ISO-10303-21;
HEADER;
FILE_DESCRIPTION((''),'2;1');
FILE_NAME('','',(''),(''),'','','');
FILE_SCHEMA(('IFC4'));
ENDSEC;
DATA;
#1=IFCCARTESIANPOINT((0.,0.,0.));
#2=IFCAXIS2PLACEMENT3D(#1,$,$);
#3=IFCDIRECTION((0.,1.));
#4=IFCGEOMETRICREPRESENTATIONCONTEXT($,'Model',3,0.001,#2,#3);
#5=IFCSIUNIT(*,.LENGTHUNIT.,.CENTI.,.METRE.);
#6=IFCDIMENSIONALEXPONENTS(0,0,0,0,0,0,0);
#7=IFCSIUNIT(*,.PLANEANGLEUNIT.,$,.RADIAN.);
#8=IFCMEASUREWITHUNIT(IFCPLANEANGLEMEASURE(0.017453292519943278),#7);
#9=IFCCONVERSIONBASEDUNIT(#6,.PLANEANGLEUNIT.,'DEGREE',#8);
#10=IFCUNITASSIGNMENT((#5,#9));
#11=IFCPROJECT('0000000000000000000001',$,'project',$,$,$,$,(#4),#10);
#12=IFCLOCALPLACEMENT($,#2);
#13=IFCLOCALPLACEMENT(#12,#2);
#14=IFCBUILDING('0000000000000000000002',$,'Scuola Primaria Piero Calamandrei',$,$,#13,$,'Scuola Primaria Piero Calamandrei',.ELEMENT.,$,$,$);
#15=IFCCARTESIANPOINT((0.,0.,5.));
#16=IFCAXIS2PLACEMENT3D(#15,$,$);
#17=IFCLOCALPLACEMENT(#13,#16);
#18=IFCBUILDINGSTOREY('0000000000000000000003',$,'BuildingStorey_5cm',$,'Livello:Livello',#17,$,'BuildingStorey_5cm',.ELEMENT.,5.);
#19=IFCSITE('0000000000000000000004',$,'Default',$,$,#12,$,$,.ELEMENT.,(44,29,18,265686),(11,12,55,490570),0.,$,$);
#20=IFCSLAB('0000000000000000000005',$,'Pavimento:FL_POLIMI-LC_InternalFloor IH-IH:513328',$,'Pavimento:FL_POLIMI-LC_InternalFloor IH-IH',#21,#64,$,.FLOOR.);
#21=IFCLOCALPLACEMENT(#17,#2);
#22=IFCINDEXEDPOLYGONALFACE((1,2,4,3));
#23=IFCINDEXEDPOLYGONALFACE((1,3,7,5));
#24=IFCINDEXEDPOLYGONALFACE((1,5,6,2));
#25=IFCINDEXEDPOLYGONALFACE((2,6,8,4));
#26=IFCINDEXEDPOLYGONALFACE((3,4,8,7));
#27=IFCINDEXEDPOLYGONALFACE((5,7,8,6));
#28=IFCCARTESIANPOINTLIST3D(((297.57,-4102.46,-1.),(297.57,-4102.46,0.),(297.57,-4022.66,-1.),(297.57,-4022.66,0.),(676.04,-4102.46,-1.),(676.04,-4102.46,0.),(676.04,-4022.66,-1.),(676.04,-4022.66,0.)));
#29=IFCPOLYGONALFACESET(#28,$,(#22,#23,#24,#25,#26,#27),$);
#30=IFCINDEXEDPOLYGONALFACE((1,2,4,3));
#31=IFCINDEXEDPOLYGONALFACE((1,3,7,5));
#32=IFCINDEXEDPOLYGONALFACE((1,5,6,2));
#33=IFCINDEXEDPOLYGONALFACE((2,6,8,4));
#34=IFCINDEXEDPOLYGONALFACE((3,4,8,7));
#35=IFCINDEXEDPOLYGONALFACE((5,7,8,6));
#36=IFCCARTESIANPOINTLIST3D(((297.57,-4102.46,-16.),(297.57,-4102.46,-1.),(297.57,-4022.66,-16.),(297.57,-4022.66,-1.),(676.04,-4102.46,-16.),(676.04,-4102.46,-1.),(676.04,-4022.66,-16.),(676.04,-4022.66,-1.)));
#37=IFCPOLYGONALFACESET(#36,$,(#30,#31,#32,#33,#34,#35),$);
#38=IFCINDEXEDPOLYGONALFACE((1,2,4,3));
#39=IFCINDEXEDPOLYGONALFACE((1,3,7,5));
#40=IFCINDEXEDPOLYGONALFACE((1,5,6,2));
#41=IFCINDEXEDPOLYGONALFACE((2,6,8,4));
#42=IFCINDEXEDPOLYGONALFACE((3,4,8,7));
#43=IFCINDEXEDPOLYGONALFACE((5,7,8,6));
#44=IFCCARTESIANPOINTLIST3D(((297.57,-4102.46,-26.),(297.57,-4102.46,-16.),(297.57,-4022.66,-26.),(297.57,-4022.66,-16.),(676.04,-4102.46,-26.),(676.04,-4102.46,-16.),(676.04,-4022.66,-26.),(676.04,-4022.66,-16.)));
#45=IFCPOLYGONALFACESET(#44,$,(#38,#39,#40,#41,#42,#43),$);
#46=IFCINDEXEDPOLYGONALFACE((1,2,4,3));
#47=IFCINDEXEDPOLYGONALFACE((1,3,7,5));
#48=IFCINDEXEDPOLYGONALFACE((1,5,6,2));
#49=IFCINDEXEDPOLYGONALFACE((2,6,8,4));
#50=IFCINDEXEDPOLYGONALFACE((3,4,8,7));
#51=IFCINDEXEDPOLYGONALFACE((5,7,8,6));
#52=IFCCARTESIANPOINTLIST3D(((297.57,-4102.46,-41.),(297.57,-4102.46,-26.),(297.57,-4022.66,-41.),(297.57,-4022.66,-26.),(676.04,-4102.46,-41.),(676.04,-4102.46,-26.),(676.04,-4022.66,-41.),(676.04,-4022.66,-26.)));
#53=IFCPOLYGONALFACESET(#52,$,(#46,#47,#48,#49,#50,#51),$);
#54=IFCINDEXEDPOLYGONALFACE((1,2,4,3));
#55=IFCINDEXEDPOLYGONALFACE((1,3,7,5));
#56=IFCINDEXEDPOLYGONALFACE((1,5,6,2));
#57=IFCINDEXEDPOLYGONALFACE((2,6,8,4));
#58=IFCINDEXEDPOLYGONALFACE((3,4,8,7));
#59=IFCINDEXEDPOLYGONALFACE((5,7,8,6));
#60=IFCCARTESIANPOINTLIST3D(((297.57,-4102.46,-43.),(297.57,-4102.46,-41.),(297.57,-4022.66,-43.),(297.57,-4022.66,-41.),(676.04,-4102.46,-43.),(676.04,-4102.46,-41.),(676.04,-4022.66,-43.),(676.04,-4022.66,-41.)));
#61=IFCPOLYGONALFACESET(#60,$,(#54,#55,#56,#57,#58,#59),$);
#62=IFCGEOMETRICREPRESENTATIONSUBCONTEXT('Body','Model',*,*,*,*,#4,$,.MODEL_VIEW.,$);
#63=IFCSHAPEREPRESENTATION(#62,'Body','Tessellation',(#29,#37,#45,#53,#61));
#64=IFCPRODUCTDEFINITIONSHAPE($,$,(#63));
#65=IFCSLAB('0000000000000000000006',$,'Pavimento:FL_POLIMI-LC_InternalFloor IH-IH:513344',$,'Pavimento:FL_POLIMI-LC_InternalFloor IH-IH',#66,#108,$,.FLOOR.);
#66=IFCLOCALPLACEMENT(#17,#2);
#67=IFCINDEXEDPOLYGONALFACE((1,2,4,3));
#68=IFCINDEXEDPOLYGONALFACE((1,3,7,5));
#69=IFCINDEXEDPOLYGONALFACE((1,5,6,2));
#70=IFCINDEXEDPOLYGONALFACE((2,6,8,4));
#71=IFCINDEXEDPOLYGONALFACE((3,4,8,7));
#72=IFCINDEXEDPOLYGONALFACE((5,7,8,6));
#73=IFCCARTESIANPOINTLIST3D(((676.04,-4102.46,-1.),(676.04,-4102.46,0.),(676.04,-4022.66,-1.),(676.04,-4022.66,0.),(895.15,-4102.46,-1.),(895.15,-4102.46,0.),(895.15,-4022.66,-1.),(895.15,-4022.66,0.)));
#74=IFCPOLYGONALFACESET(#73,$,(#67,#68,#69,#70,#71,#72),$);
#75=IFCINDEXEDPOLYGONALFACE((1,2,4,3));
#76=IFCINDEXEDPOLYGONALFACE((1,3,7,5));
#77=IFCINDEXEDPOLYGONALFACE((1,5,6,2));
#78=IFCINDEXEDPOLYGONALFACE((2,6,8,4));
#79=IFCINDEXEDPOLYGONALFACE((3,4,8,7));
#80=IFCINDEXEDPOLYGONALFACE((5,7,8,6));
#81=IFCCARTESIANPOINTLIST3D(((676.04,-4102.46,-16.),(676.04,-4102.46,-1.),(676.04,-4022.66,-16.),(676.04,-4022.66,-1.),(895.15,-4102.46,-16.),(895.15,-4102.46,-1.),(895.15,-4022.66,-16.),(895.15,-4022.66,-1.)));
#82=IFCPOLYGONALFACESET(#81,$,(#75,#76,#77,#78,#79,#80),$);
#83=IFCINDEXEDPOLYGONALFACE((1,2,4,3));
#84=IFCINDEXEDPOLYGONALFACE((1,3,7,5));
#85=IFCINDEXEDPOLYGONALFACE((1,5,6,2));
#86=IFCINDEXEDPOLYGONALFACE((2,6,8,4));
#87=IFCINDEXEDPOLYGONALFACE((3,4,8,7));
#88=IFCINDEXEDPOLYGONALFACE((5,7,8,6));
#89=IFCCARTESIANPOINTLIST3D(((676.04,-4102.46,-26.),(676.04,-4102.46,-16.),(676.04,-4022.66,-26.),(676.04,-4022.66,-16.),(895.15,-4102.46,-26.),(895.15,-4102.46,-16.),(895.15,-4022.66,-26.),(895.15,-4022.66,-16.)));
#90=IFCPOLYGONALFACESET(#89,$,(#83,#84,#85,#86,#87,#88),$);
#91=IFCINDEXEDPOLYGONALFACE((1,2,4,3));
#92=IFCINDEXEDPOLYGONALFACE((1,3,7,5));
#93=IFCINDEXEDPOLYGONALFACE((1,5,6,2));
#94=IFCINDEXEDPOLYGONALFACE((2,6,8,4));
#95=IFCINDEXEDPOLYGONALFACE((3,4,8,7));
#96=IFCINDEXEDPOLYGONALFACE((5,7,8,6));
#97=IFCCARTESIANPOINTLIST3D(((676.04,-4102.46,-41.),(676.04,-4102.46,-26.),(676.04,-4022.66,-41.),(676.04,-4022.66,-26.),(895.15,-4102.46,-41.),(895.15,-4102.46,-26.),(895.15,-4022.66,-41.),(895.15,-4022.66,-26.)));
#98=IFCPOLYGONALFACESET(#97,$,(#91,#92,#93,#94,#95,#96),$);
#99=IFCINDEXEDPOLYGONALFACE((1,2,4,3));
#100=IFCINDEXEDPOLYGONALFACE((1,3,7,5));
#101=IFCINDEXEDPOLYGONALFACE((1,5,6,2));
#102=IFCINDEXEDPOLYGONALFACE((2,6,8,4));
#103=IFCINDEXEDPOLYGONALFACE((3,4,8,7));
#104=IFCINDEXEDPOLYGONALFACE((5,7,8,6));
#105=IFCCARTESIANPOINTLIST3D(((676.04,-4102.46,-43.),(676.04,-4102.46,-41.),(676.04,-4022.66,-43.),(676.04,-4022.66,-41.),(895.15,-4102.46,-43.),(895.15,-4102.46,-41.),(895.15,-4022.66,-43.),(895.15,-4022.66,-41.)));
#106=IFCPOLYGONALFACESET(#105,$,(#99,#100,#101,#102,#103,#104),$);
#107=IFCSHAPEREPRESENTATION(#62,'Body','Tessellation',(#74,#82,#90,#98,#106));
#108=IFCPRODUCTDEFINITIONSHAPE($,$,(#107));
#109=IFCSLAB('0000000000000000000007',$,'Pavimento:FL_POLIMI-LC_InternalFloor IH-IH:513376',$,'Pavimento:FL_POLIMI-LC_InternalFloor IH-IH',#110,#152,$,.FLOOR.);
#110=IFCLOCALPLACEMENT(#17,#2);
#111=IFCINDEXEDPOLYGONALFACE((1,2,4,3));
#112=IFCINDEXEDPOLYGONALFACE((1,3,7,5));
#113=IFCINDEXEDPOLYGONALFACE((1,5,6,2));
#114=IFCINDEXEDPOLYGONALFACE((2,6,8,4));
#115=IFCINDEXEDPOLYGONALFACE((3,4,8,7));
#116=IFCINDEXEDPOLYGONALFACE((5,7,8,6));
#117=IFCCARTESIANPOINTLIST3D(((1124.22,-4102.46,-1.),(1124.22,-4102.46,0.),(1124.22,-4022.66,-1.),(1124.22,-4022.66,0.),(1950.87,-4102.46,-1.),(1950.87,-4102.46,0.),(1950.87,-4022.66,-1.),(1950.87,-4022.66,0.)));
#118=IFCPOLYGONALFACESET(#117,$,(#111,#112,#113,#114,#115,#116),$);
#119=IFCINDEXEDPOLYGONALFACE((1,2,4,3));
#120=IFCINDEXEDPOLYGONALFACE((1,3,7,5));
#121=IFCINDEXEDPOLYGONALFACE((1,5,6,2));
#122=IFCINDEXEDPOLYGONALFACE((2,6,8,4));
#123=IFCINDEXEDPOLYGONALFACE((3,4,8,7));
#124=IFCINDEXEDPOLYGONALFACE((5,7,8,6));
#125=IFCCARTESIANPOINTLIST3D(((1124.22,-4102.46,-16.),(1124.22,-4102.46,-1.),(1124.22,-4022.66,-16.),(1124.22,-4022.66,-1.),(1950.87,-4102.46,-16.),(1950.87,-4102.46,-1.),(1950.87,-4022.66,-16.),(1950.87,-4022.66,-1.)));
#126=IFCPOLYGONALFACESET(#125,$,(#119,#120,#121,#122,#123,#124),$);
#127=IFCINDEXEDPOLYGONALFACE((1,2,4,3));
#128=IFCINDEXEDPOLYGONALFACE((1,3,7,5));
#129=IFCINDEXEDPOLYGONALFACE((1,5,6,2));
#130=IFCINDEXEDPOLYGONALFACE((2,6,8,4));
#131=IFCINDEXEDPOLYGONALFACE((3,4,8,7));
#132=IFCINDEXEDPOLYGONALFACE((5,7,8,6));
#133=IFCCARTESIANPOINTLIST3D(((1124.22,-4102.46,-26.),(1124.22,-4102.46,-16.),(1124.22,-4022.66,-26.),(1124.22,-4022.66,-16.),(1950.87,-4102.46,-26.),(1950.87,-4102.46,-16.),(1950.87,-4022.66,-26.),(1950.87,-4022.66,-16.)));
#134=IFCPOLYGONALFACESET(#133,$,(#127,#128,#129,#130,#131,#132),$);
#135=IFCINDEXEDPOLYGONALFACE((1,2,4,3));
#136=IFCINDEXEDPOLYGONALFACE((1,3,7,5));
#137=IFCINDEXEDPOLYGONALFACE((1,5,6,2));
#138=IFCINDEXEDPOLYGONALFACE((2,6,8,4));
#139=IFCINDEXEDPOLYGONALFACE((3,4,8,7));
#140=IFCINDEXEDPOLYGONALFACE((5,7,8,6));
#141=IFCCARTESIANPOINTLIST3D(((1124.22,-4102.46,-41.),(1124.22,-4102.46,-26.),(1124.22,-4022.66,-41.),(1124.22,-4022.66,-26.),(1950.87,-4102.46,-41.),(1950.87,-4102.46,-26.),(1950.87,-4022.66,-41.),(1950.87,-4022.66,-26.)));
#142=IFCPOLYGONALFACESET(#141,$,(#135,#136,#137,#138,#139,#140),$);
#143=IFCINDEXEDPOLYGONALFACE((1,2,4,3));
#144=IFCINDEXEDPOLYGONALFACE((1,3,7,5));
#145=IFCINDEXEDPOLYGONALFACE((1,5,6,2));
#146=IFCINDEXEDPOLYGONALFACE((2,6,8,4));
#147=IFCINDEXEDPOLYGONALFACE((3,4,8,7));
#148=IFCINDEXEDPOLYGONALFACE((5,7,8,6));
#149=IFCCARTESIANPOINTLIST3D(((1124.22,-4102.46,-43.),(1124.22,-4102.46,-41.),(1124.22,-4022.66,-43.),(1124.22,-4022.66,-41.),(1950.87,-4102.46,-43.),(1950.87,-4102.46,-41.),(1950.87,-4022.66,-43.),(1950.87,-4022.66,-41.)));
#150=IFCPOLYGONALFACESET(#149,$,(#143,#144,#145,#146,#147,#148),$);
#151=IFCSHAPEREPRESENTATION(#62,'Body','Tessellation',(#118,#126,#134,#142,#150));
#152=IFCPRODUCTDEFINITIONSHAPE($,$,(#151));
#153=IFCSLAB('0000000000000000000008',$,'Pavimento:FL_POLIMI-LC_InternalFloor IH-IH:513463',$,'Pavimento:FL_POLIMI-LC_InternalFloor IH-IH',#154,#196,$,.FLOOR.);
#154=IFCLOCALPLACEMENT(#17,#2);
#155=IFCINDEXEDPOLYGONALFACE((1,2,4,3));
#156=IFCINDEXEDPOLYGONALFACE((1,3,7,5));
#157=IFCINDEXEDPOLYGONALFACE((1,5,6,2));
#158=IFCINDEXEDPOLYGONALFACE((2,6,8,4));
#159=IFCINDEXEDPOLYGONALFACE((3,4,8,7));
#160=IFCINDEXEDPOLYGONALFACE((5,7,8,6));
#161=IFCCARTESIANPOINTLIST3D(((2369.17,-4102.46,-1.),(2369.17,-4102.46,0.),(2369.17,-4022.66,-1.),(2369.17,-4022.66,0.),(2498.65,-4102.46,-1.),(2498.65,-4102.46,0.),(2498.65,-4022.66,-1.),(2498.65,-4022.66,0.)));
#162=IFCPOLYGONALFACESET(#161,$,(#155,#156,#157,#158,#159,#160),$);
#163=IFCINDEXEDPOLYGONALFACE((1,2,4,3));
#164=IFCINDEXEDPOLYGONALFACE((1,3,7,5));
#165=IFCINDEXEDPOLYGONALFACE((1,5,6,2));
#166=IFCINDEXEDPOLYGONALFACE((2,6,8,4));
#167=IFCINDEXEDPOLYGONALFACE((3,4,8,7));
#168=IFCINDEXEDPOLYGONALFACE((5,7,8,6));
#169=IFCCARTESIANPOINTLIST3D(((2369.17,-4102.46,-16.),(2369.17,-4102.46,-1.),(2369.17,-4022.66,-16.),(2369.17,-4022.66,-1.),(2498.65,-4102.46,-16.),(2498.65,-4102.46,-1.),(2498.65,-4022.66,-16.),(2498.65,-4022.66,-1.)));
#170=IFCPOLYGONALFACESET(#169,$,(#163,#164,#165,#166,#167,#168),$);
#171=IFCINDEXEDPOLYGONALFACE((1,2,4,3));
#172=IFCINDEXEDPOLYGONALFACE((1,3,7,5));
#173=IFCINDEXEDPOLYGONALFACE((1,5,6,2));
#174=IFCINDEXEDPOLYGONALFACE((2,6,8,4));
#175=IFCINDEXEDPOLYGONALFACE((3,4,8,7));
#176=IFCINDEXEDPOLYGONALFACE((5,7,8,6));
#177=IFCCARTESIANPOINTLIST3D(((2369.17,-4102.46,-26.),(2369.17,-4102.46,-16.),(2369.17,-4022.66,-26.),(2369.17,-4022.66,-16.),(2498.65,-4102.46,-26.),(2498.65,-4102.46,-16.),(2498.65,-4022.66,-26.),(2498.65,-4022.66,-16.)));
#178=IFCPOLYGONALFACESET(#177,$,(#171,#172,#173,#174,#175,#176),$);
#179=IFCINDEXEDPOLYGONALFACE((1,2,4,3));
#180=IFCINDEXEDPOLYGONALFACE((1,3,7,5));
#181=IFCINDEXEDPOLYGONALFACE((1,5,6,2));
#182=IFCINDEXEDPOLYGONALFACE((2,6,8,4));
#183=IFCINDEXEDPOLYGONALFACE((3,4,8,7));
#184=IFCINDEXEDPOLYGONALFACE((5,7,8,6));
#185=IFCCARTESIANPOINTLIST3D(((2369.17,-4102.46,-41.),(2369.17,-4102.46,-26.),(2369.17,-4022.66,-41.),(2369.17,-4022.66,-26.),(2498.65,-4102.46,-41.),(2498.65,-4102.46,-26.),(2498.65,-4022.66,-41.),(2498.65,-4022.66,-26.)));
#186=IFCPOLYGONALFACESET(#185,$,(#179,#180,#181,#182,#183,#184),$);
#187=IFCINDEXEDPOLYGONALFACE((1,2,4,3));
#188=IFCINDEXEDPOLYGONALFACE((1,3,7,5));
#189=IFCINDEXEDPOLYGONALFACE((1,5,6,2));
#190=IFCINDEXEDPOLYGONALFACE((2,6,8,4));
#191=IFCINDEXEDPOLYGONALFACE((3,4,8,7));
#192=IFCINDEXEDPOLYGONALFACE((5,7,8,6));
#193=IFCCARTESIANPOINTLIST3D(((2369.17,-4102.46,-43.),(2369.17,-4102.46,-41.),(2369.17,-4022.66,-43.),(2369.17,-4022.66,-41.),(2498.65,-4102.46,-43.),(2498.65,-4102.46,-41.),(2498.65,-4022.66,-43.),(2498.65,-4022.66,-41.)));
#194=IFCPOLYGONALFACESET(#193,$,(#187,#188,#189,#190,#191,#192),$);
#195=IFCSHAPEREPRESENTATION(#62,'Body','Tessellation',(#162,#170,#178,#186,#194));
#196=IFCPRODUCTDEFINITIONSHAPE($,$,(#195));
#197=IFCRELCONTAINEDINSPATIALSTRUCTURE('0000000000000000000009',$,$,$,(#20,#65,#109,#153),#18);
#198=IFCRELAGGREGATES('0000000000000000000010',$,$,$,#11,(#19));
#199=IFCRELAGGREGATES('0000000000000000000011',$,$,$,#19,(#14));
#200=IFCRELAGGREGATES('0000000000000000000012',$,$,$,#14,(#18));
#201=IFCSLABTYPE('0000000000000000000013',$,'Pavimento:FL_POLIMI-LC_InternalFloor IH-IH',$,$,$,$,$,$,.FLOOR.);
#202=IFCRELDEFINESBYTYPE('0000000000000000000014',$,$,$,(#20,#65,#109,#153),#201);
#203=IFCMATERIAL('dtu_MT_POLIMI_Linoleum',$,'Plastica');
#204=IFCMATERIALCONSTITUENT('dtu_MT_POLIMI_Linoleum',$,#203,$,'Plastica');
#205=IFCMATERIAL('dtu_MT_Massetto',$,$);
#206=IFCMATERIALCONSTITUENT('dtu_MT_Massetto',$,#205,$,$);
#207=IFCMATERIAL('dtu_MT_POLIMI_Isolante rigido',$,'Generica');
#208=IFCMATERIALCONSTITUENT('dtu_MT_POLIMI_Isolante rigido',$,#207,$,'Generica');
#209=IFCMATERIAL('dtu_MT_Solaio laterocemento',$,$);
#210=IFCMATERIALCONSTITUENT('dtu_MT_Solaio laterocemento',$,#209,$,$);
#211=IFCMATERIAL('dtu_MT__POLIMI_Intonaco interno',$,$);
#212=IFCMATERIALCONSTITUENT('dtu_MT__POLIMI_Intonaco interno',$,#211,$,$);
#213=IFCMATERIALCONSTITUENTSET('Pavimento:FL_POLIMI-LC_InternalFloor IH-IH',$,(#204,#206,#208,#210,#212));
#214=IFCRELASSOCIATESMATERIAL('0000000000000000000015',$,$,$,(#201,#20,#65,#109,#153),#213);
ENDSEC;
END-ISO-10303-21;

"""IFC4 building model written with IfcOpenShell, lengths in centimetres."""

from ifc_helpers import new_model, entity, si_unit, converted_unit, direction, frame, origin, place, context, subcontext, project, spatial, indexed_curve, outline, extrude, material, constituent, constituent_set, type_object, element, save


model = new_model("IFC4")

# Units and contexts
model_context = context("Model", 3, precision=0.001, world=origin(), true_north=direction((0.0, 1.0)))
body_context = subcontext(model_context, "Body", "Model", "MODEL_VIEW")
ifc_project = project(units=[si_unit("LENGTHUNIT", "METRE", prefix="CENTI"), converted_unit("PLANEANGLEUNIT", "DEGREE", entity("IfcPlaneAngleMeasure", 0.017453292519943278), si_unit("PLANEANGLEUNIT", "RADIAN"), dimensions=[0, 0, 0, 0, 0, 0, 0])], contexts=[model_context])

# Site, building, storey
site_placement = place(None, origin())
site = spatial("IfcSite", under=ifc_project, at=site_placement, Name="Default", CompositionType="ELEMENT", RefLatitude=(44, 29, 18, 265686), RefLongitude=(11, 12, 55, 490570), RefElevation=0.0)
building_placement = place(site_placement, origin())
building = spatial("IfcBuilding", under=site, at=building_placement, Name="Scuola Primaria Piero Calamandrei", LongName="Scuola Primaria Piero Calamandrei", CompositionType="ELEMENT")
storey_placement = place(building_placement, frame((0.0, 0.0, 5.0)))
storey = spatial("IfcBuildingStorey", under=building, at=storey_placement, Name="BuildingStorey_5cm", ObjectType="Livello:Livello", LongName="BuildingStorey_5cm", CompositionType="ELEMENT", Elevation=5.0)

# Slabs
ifc_material_1 = material(Name="dtu_MT_POLIMI_Linoleum", Category="Plastica")
ifc_constituent_1 = constituent(ifc_material_1, Name="dtu_MT_POLIMI_Linoleum", Category="Plastica")
ifc_material_2 = material(Name="dtu_MT_Massetto")
ifc_constituent_2 = constituent(ifc_material_2, Name="dtu_MT_Massetto")
ifc_material_3 = material(Name="dtu_MT_POLIMI_Isolante rigido", Category="Generica")
ifc_constituent_3 = constituent(ifc_material_3, Name="dtu_MT_POLIMI_Isolante rigido", Category="Generica")
ifc_material_4 = material(Name="dtu_MT_Solaio laterocemento")
ifc_constituent_4 = constituent(ifc_material_4, Name="dtu_MT_Solaio laterocemento")
ifc_material_5 = material(Name="dtu_MT__POLIMI_Intonaco interno")
ifc_constituent_5 = constituent(ifc_material_5, Name="dtu_MT__POLIMI_Intonaco interno")
ifc_constituent_set_1 = constituent_set(constituents=[ifc_constituent_1, ifc_constituent_2, ifc_constituent_3, ifc_constituent_4, ifc_constituent_5], Name="Pavimento:FL_POLIMI-LC_InternalFloor IH-IH")
slab_type_1 = type_object("IfcSlabType", Name="Pavimento:FL_POLIMI-LC_InternalFloor IH-IH", PredefinedType="FLOOR", material=ifc_constituent_set_1)
slab_1_placement = place(storey_placement, origin())
element("IfcSlab", 1, at=slab_1_placement, inside=storey, type_object=slab_type_1, material=ifc_constituent_set_1, Name="Pavimento:FL_POLIMI-LC_InternalFloor IH-IH:513328", ObjectType="Pavimento:FL_POLIMI-LC_InternalFloor IH-IH", PredefinedType="FLOOR", context=body_context, shape_type="SweptSolid", body=[
    extrude(outline(indexed_curve([(-39.9, -189.23), (39.9, -189.23), (39.9, 189.23), (-39.9, 189.23), (-39.9, -189.23)], self_intersect=False)), frame((486.81, -4062.56, -1.0), z_axis=(0.0, 0.0, 1.0), x_axis=(0.0, 1.0, 0.0)), (0.0, 0.0, 1.0), 1.0),
    extrude(outline(indexed_curve([(-39.9, -189.23), (39.9, -189.23), (39.9, 189.23), (-39.9, 189.23), (-39.9, -189.23)], self_intersect=False)), frame((486.81, -4062.56, -16.0), z_axis=(0.0, 0.0, 1.0), x_axis=(0.0, 1.0, 0.0)), (0.0, 0.0, 1.0), 15.0),
    extrude(outline(indexed_curve([(-39.9, -189.23), (39.9, -189.23), (39.9, 189.23), (-39.9, 189.23), (-39.9, -189.23)], self_intersect=False)), frame((486.81, -4062.56, -26.0), z_axis=(0.0, 0.0, 1.0), x_axis=(0.0, 1.0, 0.0)), (0.0, 0.0, 1.0), 10.0),
    extrude(outline(indexed_curve([(-39.9, -189.23), (39.9, -189.23), (39.9, 189.23), (-39.9, 189.23), (-39.9, -189.23)], self_intersect=False)), frame((486.81, -4062.56, -41.0), z_axis=(0.0, 0.0, 1.0), x_axis=(0.0, 1.0, 0.0)), (0.0, 0.0, 1.0), 15.0),
    extrude(outline(indexed_curve([(-39.9, -189.23), (39.9, -189.23), (39.9, 189.23), (-39.9, 189.23), (-39.9, -189.23)], self_intersect=False)), frame((486.81, -4062.56, -43.0), z_axis=(0.0, 0.0, 1.0), x_axis=(0.0, 1.0, 0.0)), (0.0, 0.0, 1.0), 2.0),
])
slab_2_placement = place(storey_placement, origin())
element("IfcSlab", 2, at=slab_2_placement, inside=storey, type_object=slab_type_1, material=ifc_constituent_set_1, Name="Pavimento:FL_POLIMI-LC_InternalFloor IH-IH:513344", ObjectType="Pavimento:FL_POLIMI-LC_InternalFloor IH-IH", PredefinedType="FLOOR", context=body_context, shape_type="SweptSolid", body=[
    extrude(outline(indexed_curve([(-109.56, -39.9), (109.56, -39.9), (109.56, 39.9), (-109.56, 39.9), (-109.56, -39.9)], self_intersect=False)), frame((785.6, -4062.56, -1.0)), (0.0, 0.0, 1.0), 1.0),
    extrude(outline(indexed_curve([(-109.56, -39.9), (109.56, -39.9), (109.56, 39.9), (-109.56, 39.9), (-109.56, -39.9)], self_intersect=False)), frame((785.6, -4062.56, -16.0)), (0.0, 0.0, 1.0), 15.0),
    extrude(outline(indexed_curve([(-109.56, -39.9), (109.56, -39.9), (109.56, 39.9), (-109.56, 39.9), (-109.56, -39.9)], self_intersect=False)), frame((785.6, -4062.56, -26.0)), (0.0, 0.0, 1.0), 10.0),
    extrude(outline(indexed_curve([(-109.56, -39.9), (109.56, -39.9), (109.56, 39.9), (-109.56, 39.9), (-109.56, -39.9)], self_intersect=False)), frame((785.6, -4062.56, -41.0)), (0.0, 0.0, 1.0), 15.0),
    extrude(outline(indexed_curve([(-109.56, -39.9), (109.56, -39.9), (109.56, 39.9), (-109.56, 39.9), (-109.56, -39.9)], self_intersect=False)), frame((785.6, -4062.56, -43.0)), (0.0, 0.0, 1.0), 2.0),
])
slab_3_placement = place(storey_placement, origin())
element("IfcSlab", 3, at=slab_3_placement, inside=storey, type_object=slab_type_1, material=ifc_constituent_set_1, Name="Pavimento:FL_POLIMI-LC_InternalFloor IH-IH:513376", ObjectType="Pavimento:FL_POLIMI-LC_InternalFloor IH-IH", PredefinedType="FLOOR", context=body_context, shape_type="SweptSolid", body=[
    extrude(outline(indexed_curve([(-39.9, -413.32), (39.9, -413.32), (39.9, 413.32), (-39.9, 413.32), (-39.9, -413.32)], self_intersect=False)), frame((1537.55, -4062.56, -1.0), z_axis=(0.0, 0.0, 1.0), x_axis=(0.0, 1.0, 0.0)), (0.0, 0.0, 1.0), 1.0),
    extrude(outline(indexed_curve([(-39.9, -413.32), (39.9, -413.32), (39.9, 413.32), (-39.9, 413.32), (-39.9, -413.32)], self_intersect=False)), frame((1537.55, -4062.56, -16.0), z_axis=(0.0, 0.0, 1.0), x_axis=(0.0, 1.0, 0.0)), (0.0, 0.0, 1.0), 15.0),
    extrude(outline(indexed_curve([(-39.9, -413.32), (39.9, -413.32), (39.9, 413.32), (-39.9, 413.32), (-39.9, -413.32)], self_intersect=False)), frame((1537.55, -4062.56, -26.0), z_axis=(0.0, 0.0, 1.0), x_axis=(0.0, 1.0, 0.0)), (0.0, 0.0, 1.0), 10.0),
    extrude(outline(indexed_curve([(-39.9, -413.32), (39.9, -413.32), (39.9, 413.32), (-39.9, 413.32), (-39.9, -413.32)], self_intersect=False)), frame((1537.55, -4062.56, -41.0), z_axis=(0.0, 0.0, 1.0), x_axis=(0.0, 1.0, 0.0)), (0.0, 0.0, 1.0), 15.0),
    extrude(outline(indexed_curve([(-39.9, -413.32), (39.9, -413.32), (39.9, 413.32), (-39.9, 413.32), (-39.9, -413.32)], self_intersect=False)), frame((1537.55, -4062.56, -43.0), z_axis=(0.0, 0.0, 1.0), x_axis=(0.0, 1.0, 0.0)), (0.0, 0.0, 1.0), 2.0),
])
slab_4_placement = place(storey_placement, origin())
element("IfcSlab", 4, at=slab_4_placement, inside=storey, type_object=slab_type_1, material=ifc_constituent_set_1, Name="Pavimento:FL_POLIMI-LC_InternalFloor IH-IH:513463", ObjectType="Pavimento:FL_POLIMI-LC_InternalFloor IH-IH", PredefinedType="FLOOR", context=body_context, shape_type="SweptSolid", body=[
    extrude(outline(indexed_curve([(-39.9, -64.74), (39.9, -64.74), (39.9, 64.74), (-39.9, 64.74), (-39.9, -64.74)], self_intersect=False)), frame((2433.91, -4062.56, -1.0), z_axis=(0.0, 0.0, 1.0), x_axis=(0.0, 1.0, 0.0)), (0.0, 0.0, 1.0), 1.0),
    extrude(outline(indexed_curve([(-39.9, -64.74), (39.9, -64.74), (39.9, 64.74), (-39.9, 64.74), (-39.9, -64.74)], self_intersect=False)), frame((2433.91, -4062.56, -16.0), z_axis=(0.0, 0.0, 1.0), x_axis=(0.0, 1.0, 0.0)), (0.0, 0.0, 1.0), 15.0),
    extrude(outline(indexed_curve([(-39.9, -64.74), (39.9, -64.74), (39.9, 64.74), (-39.9, 64.74), (-39.9, -64.74)], self_intersect=False)), frame((2433.91, -4062.56, -26.0), z_axis=(0.0, 0.0, 1.0), x_axis=(0.0, 1.0, 0.0)), (0.0, 0.0, 1.0), 10.0),
    extrude(outline(indexed_curve([(-39.9, -64.74), (39.9, -64.74), (39.9, 64.74), (-39.9, 64.74), (-39.9, -64.74)], self_intersect=False)), frame((2433.91, -4062.56, -41.0), z_axis=(0.0, 0.0, 1.0), x_axis=(0.0, 1.0, 0.0)), (0.0, 0.0, 1.0), 15.0),
    extrude(outline(indexed_curve([(-39.9, -64.74), (39.9, -64.74), (39.9, 64.74), (-39.9, 64.74), (-39.9, -64.74)], self_intersect=False)), frame((2433.91, -4062.56, -43.0), z_axis=(0.0, 0.0, 1.0), x_axis=(0.0, 1.0, 0.0)), (0.0, 0.0, 1.0), 2.0),
])

save(model, "model.ifc")
